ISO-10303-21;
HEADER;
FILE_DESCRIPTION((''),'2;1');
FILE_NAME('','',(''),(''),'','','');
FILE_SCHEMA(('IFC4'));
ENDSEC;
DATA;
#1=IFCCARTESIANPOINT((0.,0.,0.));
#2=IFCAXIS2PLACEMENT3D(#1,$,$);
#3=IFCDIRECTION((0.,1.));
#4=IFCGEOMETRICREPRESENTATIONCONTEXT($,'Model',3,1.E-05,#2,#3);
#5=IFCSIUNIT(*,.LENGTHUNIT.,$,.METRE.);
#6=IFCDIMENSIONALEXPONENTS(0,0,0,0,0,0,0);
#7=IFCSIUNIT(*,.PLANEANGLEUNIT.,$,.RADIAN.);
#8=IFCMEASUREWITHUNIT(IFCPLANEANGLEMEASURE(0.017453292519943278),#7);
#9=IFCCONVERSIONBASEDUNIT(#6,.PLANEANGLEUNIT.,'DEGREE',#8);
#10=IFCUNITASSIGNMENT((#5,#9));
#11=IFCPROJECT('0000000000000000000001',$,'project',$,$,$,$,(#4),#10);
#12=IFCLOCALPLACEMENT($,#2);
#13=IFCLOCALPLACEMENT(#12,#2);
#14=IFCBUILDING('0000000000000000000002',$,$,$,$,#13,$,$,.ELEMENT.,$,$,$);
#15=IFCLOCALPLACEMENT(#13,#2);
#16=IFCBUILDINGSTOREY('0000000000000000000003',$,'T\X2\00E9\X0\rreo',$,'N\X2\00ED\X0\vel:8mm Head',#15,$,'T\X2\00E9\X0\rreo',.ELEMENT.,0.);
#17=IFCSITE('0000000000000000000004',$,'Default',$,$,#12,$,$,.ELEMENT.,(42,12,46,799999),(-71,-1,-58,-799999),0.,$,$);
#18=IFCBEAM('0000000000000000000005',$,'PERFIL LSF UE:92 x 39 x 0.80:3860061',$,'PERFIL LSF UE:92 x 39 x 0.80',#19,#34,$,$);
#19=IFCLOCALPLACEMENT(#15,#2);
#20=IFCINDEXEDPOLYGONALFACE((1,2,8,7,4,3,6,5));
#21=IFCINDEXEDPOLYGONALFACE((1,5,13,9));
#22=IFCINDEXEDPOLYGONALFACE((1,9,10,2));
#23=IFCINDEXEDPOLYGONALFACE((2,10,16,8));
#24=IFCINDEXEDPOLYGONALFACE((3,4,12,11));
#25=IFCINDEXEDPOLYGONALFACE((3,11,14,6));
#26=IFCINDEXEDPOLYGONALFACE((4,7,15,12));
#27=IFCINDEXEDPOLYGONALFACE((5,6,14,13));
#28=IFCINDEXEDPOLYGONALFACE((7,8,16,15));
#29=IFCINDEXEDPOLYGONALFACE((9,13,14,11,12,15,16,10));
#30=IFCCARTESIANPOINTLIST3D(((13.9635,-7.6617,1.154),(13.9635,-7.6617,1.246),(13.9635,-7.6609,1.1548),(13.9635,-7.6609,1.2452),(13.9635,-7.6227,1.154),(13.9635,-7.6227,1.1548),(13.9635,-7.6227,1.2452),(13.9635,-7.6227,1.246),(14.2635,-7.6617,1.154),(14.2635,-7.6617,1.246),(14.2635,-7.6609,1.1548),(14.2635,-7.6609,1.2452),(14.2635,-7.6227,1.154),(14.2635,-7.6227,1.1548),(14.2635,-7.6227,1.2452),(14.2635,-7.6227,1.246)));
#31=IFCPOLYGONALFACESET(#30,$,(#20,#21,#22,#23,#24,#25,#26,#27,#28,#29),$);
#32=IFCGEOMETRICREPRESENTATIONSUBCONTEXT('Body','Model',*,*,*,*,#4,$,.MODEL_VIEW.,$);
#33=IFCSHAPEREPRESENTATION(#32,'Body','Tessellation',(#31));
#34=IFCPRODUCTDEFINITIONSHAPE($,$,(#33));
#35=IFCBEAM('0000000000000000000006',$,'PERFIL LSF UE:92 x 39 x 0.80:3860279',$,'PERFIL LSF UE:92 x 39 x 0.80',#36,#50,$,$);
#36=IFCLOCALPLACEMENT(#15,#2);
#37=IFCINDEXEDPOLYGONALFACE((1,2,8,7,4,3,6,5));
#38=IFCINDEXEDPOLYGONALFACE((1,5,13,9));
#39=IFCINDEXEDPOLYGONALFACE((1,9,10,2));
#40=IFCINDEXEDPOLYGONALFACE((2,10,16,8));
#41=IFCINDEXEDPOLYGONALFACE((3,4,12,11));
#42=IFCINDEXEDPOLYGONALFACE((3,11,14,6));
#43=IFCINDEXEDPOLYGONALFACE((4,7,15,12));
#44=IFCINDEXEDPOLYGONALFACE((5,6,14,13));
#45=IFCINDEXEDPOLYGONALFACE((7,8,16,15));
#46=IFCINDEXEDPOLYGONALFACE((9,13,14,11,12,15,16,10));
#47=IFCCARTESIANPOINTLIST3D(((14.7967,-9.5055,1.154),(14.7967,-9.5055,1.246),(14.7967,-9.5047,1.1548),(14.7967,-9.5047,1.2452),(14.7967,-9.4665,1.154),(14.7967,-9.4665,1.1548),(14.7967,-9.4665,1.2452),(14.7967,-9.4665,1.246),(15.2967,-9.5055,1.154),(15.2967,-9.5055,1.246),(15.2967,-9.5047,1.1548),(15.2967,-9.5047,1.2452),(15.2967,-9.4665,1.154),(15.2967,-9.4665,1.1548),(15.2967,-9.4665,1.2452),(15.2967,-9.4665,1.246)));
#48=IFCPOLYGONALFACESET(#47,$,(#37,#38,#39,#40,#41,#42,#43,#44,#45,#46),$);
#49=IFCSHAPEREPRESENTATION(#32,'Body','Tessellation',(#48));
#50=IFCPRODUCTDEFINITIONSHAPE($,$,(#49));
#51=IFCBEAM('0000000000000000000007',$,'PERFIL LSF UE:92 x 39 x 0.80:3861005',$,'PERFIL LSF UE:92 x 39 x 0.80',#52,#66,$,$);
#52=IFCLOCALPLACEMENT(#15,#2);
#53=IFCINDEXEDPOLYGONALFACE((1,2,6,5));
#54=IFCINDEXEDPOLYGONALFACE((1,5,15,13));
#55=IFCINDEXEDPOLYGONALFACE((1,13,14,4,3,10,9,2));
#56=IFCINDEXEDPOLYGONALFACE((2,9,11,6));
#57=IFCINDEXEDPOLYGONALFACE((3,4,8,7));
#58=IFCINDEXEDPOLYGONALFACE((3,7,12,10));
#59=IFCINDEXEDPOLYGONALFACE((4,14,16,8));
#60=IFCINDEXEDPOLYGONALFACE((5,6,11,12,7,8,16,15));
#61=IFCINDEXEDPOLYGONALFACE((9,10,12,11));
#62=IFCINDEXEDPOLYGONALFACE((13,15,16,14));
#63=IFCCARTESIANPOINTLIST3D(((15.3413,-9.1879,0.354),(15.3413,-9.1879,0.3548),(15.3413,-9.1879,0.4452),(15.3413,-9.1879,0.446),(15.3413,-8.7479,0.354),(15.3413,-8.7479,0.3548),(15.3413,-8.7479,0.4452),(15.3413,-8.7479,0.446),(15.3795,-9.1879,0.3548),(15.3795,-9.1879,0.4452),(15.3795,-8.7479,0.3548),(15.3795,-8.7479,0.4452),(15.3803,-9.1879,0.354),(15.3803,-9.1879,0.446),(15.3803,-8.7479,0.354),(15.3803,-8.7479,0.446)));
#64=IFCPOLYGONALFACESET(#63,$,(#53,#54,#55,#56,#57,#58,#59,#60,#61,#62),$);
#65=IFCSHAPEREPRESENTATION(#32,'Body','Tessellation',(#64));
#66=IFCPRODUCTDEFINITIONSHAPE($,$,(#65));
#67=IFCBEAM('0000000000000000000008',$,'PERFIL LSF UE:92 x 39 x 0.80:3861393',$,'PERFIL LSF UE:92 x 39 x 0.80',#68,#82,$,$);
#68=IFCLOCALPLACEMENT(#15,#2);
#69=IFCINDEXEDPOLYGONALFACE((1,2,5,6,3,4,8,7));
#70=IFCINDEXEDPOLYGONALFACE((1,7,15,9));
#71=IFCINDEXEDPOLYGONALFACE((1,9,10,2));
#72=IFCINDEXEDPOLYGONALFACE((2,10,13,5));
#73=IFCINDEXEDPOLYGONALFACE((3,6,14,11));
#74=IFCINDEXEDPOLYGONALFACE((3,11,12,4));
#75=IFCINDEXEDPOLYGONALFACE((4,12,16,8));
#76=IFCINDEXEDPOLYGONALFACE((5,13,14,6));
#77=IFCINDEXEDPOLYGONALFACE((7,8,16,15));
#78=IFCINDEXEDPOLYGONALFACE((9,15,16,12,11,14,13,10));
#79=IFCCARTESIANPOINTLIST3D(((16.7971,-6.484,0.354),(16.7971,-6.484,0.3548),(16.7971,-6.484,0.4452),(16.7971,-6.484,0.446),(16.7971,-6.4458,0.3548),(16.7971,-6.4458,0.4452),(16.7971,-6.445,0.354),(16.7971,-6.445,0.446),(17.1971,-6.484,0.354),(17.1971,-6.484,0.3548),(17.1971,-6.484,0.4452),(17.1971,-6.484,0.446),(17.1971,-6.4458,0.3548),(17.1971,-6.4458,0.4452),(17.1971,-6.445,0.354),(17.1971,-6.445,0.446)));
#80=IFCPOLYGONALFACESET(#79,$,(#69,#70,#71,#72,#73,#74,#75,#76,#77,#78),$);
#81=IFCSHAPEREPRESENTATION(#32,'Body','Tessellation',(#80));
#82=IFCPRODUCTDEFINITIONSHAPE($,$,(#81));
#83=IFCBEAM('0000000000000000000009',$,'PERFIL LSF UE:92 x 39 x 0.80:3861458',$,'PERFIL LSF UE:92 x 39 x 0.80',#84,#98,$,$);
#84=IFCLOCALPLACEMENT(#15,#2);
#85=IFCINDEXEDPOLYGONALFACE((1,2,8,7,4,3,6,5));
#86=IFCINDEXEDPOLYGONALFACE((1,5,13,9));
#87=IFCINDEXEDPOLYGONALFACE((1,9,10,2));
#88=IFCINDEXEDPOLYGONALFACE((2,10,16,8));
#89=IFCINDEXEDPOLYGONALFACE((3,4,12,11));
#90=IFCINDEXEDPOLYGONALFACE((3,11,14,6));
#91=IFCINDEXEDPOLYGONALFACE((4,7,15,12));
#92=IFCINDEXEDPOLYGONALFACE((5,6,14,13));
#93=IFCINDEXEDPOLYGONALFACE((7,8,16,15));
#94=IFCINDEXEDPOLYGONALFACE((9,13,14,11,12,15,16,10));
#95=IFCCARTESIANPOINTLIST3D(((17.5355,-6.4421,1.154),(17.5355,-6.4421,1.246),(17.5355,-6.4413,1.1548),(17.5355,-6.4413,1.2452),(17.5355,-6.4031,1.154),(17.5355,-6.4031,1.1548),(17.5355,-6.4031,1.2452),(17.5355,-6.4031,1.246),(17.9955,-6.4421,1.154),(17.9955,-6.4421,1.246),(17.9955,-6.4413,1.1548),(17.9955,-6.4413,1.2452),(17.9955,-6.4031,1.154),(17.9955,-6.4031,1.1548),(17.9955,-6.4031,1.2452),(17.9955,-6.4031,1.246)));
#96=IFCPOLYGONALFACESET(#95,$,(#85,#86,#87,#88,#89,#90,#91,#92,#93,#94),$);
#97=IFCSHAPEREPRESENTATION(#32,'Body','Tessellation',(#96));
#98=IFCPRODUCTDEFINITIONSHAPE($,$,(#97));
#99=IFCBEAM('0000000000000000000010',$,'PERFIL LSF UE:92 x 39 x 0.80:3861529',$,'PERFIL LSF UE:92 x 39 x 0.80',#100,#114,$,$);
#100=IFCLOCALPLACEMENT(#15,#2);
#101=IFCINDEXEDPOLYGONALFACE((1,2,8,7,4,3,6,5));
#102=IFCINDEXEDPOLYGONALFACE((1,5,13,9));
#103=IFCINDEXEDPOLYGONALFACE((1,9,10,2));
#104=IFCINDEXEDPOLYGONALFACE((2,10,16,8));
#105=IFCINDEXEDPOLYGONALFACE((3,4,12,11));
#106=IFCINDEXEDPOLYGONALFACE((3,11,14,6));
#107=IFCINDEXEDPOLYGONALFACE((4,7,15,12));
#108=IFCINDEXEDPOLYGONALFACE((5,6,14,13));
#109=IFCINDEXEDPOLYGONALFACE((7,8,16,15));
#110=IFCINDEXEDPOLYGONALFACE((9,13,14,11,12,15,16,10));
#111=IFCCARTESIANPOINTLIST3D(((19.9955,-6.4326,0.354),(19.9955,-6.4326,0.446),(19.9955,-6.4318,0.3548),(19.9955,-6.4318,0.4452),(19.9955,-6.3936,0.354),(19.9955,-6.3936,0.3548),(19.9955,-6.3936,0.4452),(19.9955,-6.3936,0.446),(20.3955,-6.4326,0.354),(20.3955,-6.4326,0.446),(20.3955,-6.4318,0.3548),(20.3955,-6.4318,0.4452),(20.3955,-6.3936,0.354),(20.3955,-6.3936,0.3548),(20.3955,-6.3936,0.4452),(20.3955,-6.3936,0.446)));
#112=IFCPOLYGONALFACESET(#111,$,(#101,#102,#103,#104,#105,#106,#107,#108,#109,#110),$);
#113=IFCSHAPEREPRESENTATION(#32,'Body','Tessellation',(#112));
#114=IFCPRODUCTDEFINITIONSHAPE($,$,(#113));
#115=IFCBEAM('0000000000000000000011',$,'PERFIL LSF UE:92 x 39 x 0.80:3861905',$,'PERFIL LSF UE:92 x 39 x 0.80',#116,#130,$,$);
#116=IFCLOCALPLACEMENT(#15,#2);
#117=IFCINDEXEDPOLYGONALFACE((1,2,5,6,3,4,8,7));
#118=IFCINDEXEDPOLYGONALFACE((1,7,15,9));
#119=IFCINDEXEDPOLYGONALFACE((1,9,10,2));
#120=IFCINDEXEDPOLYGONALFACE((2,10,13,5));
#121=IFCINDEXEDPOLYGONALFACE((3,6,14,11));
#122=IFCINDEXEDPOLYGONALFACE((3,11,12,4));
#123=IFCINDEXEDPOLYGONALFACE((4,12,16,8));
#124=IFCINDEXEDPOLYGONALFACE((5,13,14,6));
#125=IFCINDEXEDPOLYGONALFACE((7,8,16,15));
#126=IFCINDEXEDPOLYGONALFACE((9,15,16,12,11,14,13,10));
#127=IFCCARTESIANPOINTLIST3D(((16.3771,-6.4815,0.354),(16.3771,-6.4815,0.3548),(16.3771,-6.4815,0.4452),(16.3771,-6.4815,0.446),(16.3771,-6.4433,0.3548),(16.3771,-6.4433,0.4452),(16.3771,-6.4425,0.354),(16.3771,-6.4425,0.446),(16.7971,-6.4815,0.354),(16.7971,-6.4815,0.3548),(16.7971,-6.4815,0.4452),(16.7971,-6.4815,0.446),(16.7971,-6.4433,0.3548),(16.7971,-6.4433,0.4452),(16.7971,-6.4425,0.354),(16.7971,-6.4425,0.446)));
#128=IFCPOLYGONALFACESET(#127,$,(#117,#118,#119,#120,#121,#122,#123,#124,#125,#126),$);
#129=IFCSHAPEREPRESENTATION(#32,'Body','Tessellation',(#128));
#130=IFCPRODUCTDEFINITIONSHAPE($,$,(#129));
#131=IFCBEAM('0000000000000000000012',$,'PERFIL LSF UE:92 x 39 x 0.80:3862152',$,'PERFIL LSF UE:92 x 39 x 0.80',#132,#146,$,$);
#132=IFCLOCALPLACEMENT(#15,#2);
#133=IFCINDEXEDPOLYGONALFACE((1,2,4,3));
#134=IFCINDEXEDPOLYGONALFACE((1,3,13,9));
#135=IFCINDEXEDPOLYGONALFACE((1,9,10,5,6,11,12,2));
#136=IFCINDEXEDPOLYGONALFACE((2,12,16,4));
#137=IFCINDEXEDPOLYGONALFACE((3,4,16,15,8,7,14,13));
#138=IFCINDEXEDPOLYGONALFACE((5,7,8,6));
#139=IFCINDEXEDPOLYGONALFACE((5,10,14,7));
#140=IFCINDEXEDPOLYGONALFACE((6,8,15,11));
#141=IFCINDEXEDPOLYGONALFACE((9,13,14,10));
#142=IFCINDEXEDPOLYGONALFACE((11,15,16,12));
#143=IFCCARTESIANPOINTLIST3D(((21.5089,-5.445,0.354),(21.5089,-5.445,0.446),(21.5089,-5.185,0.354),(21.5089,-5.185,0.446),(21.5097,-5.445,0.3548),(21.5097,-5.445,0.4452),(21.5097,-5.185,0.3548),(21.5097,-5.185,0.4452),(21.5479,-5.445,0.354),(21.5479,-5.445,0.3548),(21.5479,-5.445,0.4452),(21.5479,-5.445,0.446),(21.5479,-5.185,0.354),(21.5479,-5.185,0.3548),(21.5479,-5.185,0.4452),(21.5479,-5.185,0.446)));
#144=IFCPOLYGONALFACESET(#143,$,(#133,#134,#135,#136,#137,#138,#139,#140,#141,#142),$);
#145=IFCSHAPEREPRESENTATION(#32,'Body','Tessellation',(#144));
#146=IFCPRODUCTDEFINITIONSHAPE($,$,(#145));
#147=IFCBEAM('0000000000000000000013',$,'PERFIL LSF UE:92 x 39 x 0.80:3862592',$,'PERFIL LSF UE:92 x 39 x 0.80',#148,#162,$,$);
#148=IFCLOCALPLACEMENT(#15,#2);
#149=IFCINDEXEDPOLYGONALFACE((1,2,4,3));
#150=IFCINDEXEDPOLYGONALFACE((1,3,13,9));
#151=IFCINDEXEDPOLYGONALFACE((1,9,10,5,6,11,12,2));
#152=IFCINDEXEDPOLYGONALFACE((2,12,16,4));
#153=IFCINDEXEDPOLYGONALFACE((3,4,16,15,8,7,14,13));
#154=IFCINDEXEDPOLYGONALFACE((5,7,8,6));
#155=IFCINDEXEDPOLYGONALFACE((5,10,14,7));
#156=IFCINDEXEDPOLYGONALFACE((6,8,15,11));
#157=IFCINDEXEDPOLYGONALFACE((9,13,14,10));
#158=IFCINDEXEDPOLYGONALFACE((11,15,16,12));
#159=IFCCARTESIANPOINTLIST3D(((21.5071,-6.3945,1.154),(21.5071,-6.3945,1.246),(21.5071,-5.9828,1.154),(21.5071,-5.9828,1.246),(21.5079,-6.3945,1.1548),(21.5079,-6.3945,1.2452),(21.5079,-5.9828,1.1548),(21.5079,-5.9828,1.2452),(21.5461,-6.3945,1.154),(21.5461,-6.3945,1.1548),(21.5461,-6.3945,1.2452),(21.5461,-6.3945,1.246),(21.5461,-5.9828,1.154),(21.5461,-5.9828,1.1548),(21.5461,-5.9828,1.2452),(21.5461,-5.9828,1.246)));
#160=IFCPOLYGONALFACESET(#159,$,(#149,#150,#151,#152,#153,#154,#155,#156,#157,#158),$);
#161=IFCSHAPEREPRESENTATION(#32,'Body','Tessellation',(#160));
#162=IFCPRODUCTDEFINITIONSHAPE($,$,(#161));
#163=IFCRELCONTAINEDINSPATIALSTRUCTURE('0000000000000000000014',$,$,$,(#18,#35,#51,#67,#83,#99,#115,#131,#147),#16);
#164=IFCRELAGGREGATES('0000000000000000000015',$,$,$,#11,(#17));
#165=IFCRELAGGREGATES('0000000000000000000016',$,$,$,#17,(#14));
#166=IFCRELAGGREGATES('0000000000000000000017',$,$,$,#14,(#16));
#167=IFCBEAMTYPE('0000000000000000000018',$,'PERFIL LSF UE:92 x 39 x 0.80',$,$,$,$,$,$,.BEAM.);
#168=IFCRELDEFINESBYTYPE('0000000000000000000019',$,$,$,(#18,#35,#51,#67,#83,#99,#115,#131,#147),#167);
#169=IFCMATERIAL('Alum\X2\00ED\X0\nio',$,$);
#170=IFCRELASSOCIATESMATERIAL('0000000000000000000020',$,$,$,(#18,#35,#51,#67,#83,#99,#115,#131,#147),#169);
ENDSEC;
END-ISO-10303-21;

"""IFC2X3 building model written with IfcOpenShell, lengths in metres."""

from ifc_helpers import new_model, entity, si_unit, converted_unit, direction, frame, origin, place, context, subcontext, project, spatial, polyline, outline, extrude, material, type_object, element, save


model = new_model("IFC2X3")

# Units and contexts
model_context = context("Model", 3, precision=1e-05, world=origin(), true_north=direction((0.0, 1.0)))
body_context = subcontext(model_context, "Body", "Model", "MODEL_VIEW")
ifc_project = project(units=[si_unit("LENGTHUNIT", "METRE"), converted_unit("PLANEANGLEUNIT", "DEGREE", entity("IfcPlaneAngleMeasure", 0.017453292519943278), si_unit("PLANEANGLEUNIT", "RADIAN"), dimensions=[0, 0, 0, 0, 0, 0, 0])], contexts=[model_context])

# Site, building, storey
site_placement = place(None, origin())
site = spatial("IfcSite", under=ifc_project, at=site_placement, Name="Default", CompositionType="ELEMENT", RefLatitude=(42, 12, 46, 799999), RefLongitude=(-71, -1, -58, -799999), RefElevation=0.0)
building_placement = place(site_placement, origin())
building = spatial("IfcBuilding", under=site, at=building_placement, CompositionType="ELEMENT")
storey_placement = place(building_placement, origin())
storey = spatial("IfcBuildingStorey", under=building, at=storey_placement, Name="Térreo", ObjectType="Nível:8mm Head", LongName="Térreo", CompositionType="ELEMENT", Elevation=0.0)

# Beams
ifc_material_1 = material(Name="Alumínio")
beam_type = type_object("IfcBeamType", Name="PERFIL LSF UE:92 x 39 x 0.80", PredefinedType="BEAM")
beam_1_placement = place(storey_placement, frame((14.2635, -8.0227, 0.0), z_axis=(0.0, 0.0, 1.0), x_axis=(-1.0, 0.0, 0.0)))
element("IfcBeam", 1, at=beam_1_placement, inside=storey, type_object=beam_type, material=ifc_material_1, Name="PERFIL LSF UE:92 x 39 x 0.80:3860061", ObjectType="PERFIL LSF UE:92 x 39 x 0.80", context=body_context, shape_type="SweptSolid", body=[
    extrude(outline(polyline([(-0.046, -0.0193), (-0.0452, -0.0193), (-0.0452, 0.0189), (0.0452, 0.0189), (0.0452, -0.0193), (0.046, -0.0193), (0.046, 0.0197), (-0.046, 0.0197), (-0.046, -0.0193)])), frame((0.0, -0.3807, 1.2), z_axis=(1.0, 0.0, 0.0), x_axis=(0.0, 0.0, -1.0)), (0.0, 0.0, 1.0), 0.3),
])
beam_2_placement = place(storey_placement, frame((15.2967, -9.8665, 0.0), z_axis=(0.0, 0.0, 1.0), x_axis=(-1.0, 0.0, 0.0)))
element("IfcBeam", 2, at=beam_2_placement, inside=storey, type_object=beam_type, material=ifc_material_1, Name="PERFIL LSF UE:92 x 39 x 0.80:3860279", ObjectType="PERFIL LSF UE:92 x 39 x 0.80", context=body_context, shape_type="SweptSolid", body=[
    extrude(outline(polyline([(-0.046, -0.0193), (-0.0452, -0.0193), (-0.0452, 0.0189), (0.0452, 0.0189), (0.0452, -0.0193), (0.046, -0.0193), (0.046, 0.0197), (-0.046, 0.0197), (-0.046, -0.0193)])), frame((0.0, -0.3807, 1.2), z_axis=(1.0, 0.0, 0.0), x_axis=(0.0, 0.0, -1.0)), (0.0, 0.0, 1.0), 0.5),
])
beam_3_placement = place(storey_placement, frame((15.7413, -8.7479, 0.0), z_axis=(0.0, 0.0, 1.0), x_axis=(0.0, -1.0, 0.0)))
element("IfcBeam", 3, at=beam_3_placement, inside=storey, type_object=beam_type, material=ifc_material_1, Name="PERFIL LSF UE:92 x 39 x 0.80:3861005", ObjectType="PERFIL LSF UE:92 x 39 x 0.80", context=body_context, shape_type="SweptSolid", body=[
    extrude(outline(polyline([(-0.046, -0.0193), (-0.0452, -0.0193), (-0.0452, 0.0189), (0.0452, 0.0189), (0.0452, -0.0193), (0.046, -0.0193), (0.046, 0.0197), (-0.046, 0.0197), (-0.046, -0.0193)])), frame((0.0, -0.3807, 0.4), z_axis=(1.0, 0.0, 0.0), x_axis=(0.0, 0.0, -1.0)), (0.0, 0.0, 1.0), 0.44),
])
beam_4_placement = place(storey_placement, frame((16.7971, -6.084, 0.0)))
element("IfcBeam", 4, at=beam_4_placement, inside=storey, type_object=beam_type, material=ifc_material_1, Name="PERFIL LSF UE:92 x 39 x 0.80:3861393", ObjectType="PERFIL LSF UE:92 x 39 x 0.80", context=body_context, shape_type="SweptSolid", body=[
    extrude(outline(polyline([(0.0452, -0.0193), (0.046, -0.0193), (0.046, 0.0197), (-0.046, 0.0197), (-0.046, -0.0193), (-0.0452, -0.0193), (-0.0452, 0.0189), (0.0452, 0.0189), (0.0452, -0.0193)])), frame((0.0, -0.3807, 0.4), z_axis=(1.0, 0.0, 0.0), x_axis=(0.0, 0.0, -1.0)), (0.0, 0.0, 1.0), 0.4),
])
beam_5_placement = place(storey_placement, frame((17.9955, -6.8031, 0.0), z_axis=(0.0, 0.0, 1.0), x_axis=(-1.0, 0.0, 0.0)))
element("IfcBeam", 5, at=beam_5_placement, inside=storey, type_object=beam_type, material=ifc_material_1, Name="PERFIL LSF UE:92 x 39 x 0.80:3861458", ObjectType="PERFIL LSF UE:92 x 39 x 0.80", context=body_context, shape_type="SweptSolid", body=[
    extrude(outline(polyline([(-0.046, -0.0193), (-0.0452, -0.0193), (-0.0452, 0.0189), (0.0452, 0.0189), (0.0452, -0.0193), (0.046, -0.0193), (0.046, 0.0197), (-0.046, 0.0197), (-0.046, -0.0193)])), frame((0.0, -0.3807, 1.2), z_axis=(1.0, 0.0, 0.0), x_axis=(0.0, 0.0, -1.0)), (0.0, 0.0, 1.0), 0.46),
])
beam_6_placement = place(storey_placement, frame((20.3955, -6.7936, 0.0), z_axis=(0.0, 0.0, 1.0), x_axis=(-1.0, 0.0, 0.0)))
element("IfcBeam", 6, at=beam_6_placement, inside=storey, type_object=beam_type, material=ifc_material_1, Name="PERFIL LSF UE:92 x 39 x 0.80:3861529", ObjectType="PERFIL LSF UE:92 x 39 x 0.80", context=body_context, shape_type="SweptSolid", body=[
    extrude(outline(polyline([(-0.046, -0.0193), (-0.0452, -0.0193), (-0.0452, 0.0189), (0.0452, 0.0189), (0.0452, -0.0193), (0.046, -0.0193), (0.046, 0.0197), (-0.046, 0.0197), (-0.046, -0.0193)])), frame((0.0, -0.3807, 0.4), z_axis=(1.0, 0.0, 0.0), x_axis=(0.0, 0.0, -1.0)), (0.0, 0.0, 1.0), 0.4),
])
beam_7_placement = place(storey_placement, frame((16.3771, -6.0815, 0.0)))
element("IfcBeam", 7, at=beam_7_placement, inside=storey, type_object=beam_type, material=ifc_material_1, Name="PERFIL LSF UE:92 x 39 x 0.80:3861905", ObjectType="PERFIL LSF UE:92 x 39 x 0.80", context=body_context, shape_type="SweptSolid", body=[
    extrude(outline(polyline([(0.0452, -0.0193), (0.046, -0.0193), (0.046, 0.0197), (-0.046, 0.0197), (-0.046, -0.0193), (-0.0452, -0.0193), (-0.0452, 0.0189), (0.0452, 0.0189), (0.0452, -0.0193)])), frame((0.0, -0.3807, 0.4), z_axis=(1.0, 0.0, 0.0), x_axis=(0.0, 0.0, -1.0)), (0.0, 0.0, 1.0), 0.42),
])
beam_8_placement = place(storey_placement, frame((21.1479, -5.445, 0.0), z_axis=(0.0, 0.0, 1.0), x_axis=(0.0, 1.0, 0.0)))
element("IfcBeam", 8, at=beam_8_placement, inside=storey, type_object=beam_type, material=ifc_material_1, Name="PERFIL LSF UE:92 x 39 x 0.80:3862152", ObjectType="PERFIL LSF UE:92 x 39 x 0.80", context=body_context, shape_type="SweptSolid", body=[
    extrude(outline(polyline([(-0.046, -0.0193), (-0.0452, -0.0193), (-0.0452, 0.0189), (0.0452, 0.0189), (0.0452, -0.0193), (0.046, -0.0193), (0.046, 0.0197), (-0.046, 0.0197), (-0.046, -0.0193)])), frame((0.0, -0.3807, 0.4), z_axis=(1.0, 0.0, 0.0), x_axis=(0.0, 0.0, -1.0)), (0.0, 0.0, 1.0), 0.26),
])
beam_9_placement = place(storey_placement, frame((21.1461, -6.3945, 0.0), z_axis=(0.0, 0.0, 1.0), x_axis=(0.0, 1.0, 0.0)))
element("IfcBeam", 9, at=beam_9_placement, inside=storey, type_object=beam_type, material=ifc_material_1, Name="PERFIL LSF UE:92 x 39 x 0.80:3862592", ObjectType="PERFIL LSF UE:92 x 39 x 0.80", context=body_context, shape_type="SweptSolid", body=[
    extrude(outline(polyline([(-0.046, -0.0193), (-0.0452, -0.0193), (-0.0452, 0.0189), (0.0452, 0.0189), (0.0452, -0.0193), (0.046, -0.0193), (0.046, 0.0197), (-0.046, 0.0197), (-0.046, -0.0193)])), frame((0.0, -0.3807, 1.2), z_axis=(1.0, 0.0, 0.0), x_axis=(0.0, 0.0, -1.0)), (0.0, 0.0, 1.0), 0.4117),
])

save(model, "model.ifc")
